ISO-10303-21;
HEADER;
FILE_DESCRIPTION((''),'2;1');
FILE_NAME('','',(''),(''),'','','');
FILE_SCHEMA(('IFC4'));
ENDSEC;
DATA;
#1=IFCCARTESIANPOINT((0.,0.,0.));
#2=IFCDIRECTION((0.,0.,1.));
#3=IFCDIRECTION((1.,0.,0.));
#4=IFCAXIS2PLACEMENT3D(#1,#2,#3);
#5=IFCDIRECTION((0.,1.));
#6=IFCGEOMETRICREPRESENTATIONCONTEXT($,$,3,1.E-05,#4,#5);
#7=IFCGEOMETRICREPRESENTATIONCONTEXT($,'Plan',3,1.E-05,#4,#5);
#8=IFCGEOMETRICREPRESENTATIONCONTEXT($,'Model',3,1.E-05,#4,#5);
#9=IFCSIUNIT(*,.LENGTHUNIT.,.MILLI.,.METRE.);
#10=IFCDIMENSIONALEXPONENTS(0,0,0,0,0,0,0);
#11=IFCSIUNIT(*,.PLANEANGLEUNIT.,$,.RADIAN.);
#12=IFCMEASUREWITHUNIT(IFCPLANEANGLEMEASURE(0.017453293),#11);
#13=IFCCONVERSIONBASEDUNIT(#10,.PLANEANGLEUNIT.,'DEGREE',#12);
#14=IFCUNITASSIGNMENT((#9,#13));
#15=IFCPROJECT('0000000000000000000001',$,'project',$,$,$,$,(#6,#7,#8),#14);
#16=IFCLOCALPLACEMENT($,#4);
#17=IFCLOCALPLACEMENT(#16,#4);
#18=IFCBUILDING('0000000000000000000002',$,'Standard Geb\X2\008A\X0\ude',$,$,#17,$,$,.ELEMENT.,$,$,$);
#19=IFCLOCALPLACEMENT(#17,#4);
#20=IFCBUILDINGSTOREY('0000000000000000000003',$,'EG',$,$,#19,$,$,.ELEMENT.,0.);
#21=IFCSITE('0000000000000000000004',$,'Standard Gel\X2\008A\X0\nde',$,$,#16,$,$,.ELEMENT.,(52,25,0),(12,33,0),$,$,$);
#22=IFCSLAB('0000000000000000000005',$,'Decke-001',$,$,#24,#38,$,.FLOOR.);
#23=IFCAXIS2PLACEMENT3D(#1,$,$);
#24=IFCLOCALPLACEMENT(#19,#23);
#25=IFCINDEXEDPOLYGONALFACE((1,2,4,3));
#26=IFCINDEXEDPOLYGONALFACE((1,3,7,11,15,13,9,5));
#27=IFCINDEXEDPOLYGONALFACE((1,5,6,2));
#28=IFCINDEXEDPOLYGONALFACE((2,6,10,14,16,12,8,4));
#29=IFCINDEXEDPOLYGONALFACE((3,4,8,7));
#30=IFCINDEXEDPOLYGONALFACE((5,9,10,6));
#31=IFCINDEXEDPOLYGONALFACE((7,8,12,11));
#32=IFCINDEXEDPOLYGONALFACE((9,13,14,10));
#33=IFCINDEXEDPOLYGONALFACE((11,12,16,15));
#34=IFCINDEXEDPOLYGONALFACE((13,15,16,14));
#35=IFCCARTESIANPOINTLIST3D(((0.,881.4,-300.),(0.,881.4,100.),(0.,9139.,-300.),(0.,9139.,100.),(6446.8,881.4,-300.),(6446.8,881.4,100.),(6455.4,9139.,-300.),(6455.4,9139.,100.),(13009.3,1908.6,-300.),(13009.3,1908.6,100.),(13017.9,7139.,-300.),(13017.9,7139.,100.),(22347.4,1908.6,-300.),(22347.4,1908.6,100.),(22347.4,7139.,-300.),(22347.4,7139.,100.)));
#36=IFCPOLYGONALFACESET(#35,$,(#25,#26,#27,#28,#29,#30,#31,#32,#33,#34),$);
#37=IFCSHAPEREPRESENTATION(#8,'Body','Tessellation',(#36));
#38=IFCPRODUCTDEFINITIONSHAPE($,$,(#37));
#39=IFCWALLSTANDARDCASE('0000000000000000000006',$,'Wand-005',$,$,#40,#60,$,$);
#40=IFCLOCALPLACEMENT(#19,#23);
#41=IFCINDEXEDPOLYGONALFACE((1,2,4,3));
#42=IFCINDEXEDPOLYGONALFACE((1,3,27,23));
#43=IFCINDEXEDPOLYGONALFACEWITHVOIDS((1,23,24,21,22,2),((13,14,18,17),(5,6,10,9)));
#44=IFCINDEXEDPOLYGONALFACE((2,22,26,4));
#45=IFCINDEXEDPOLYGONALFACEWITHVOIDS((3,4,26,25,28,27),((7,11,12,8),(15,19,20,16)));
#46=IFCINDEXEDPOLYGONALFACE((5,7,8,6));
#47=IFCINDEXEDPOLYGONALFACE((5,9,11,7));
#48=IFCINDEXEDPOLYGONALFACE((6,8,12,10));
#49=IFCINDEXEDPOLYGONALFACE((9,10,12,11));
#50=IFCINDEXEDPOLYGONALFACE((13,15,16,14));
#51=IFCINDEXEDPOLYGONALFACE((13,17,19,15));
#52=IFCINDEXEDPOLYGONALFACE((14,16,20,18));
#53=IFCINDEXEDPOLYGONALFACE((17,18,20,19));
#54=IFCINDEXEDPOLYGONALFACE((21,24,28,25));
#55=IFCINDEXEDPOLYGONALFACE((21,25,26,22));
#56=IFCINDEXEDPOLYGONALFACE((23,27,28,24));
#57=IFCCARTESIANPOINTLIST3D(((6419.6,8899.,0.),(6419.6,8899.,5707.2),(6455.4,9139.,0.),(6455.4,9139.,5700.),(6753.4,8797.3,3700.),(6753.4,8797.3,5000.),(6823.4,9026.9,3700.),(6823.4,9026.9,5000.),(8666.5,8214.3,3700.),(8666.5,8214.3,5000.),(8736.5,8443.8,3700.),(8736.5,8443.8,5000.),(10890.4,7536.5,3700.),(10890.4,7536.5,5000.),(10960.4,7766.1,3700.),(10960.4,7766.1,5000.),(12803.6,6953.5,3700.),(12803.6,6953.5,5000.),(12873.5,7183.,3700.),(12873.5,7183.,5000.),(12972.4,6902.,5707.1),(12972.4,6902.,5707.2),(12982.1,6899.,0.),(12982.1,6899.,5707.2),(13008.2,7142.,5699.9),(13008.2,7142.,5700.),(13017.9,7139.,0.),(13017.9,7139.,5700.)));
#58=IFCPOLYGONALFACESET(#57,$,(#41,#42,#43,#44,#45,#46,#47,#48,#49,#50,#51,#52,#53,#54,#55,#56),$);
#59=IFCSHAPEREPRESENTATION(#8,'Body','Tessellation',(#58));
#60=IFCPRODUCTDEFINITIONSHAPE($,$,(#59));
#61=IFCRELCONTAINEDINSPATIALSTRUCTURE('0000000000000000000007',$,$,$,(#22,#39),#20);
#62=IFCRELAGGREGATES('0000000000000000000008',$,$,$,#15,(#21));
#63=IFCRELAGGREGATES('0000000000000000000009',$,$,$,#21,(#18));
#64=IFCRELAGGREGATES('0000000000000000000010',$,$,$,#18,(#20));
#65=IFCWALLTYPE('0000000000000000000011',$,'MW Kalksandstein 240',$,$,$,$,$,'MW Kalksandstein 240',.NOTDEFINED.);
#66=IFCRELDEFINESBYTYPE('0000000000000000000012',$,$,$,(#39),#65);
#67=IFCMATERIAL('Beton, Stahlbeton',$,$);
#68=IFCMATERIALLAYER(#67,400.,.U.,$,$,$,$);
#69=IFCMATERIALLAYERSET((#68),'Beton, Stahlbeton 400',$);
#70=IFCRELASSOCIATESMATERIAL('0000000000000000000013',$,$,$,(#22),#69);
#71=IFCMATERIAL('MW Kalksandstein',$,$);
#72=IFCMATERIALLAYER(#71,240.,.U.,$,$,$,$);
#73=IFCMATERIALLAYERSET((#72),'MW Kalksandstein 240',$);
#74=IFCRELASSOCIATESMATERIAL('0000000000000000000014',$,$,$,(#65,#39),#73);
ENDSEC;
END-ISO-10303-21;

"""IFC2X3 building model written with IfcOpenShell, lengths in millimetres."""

from ifc_helpers import new_model, entity, si_unit, converted_unit, direction, frame, frame_2d, origin_with_axes, place, context, project, spatial, polyline, rectangle, outline, extrude, clip, bounded_halfspace, material, layer, layer_set, layer_usage, type_object, element, save


model = new_model("IFC2X3")

# Units and contexts
model_context = context("Model", 3, precision=1e-05, world=origin_with_axes(), true_north=direction((0.0, 1.0)))
context_of_model = context(None, 3, precision=1e-05, world=origin_with_axes(), true_north=direction((0.0, 1.0)))
plan_context = context("Plan", 3, precision=1e-05, world=origin_with_axes(), true_north=direction((0.0, 1.0)))
ifc_project = project(units=[si_unit("LENGTHUNIT", "METRE", prefix="MILLI"), converted_unit("PLANEANGLEUNIT", "DEGREE", entity("IfcPlaneAngleMeasure", 0.017453293), si_unit("PLANEANGLEUNIT", "RADIAN"), dimensions=[0, 0, 0, 0, 0, 0, 0])], contexts=[context_of_model, plan_context, model_context])

# Site, building, storey
site_placement = place(None, origin_with_axes())
site = spatial("IfcSite", under=ifc_project, at=site_placement, Name="Standard Gel\u008ande", CompositionType="ELEMENT", RefLatitude=(52, 25, 0), RefLongitude=(12, 33, 0))
building_placement = place(site_placement, origin_with_axes())
building = spatial("IfcBuilding", under=site, at=building_placement, Name="Standard Geb\u008aude", CompositionType="ELEMENT")
storey_placement = place(building_placement, origin_with_axes())
storey = spatial("IfcBuildingStorey", under=building, at=storey_placement, Name="EG", CompositionType="ELEMENT", Elevation=0.0)

# Slab
ifc_material_1 = material(Name="Beton, Stahlbeton")
ifc_layer_1 = layer(ifc_material_1, 400.0, ventilated="UNKNOWN")
ifc_layer_set_1 = layer_set([ifc_layer_1], Name="Beton, Stahlbeton 400")
ifc_layer_usage_1 = layer_usage(ifc_layer_set_1, "AXIS3", "NEGATIVE", 400.0)
slab_placement = place(storey_placement, frame((0.0, 9139.0, -300.0), z_axis=(0.0, 0.0, 1.0), x_axis=(1.0, 0.0, 0.0)))
element("IfcSlab", 1, at=slab_placement, inside=storey, material=ifc_layer_usage_1, Name="Decke-001", PredefinedType="FLOOR", context=model_context, shape_type="SweptSolid", body=[
    extrude(outline(polyline([(0.0, 0.0), (6455.4, 0.0), (13017.9, -2000.0), (22347.4, -2000.0), (22347.4, -7230.5), (13009.3, -7230.5), (6446.8, -8257.7), (0.0, -8257.7), (0.0, 0.0)])), origin_with_axes(), (0.0, 0.0, 1.0), 400.0),
])

# Shared definitions
ifc_material_2 = material(Name="MW Kalksandstein")
ifc_layer_2 = layer(ifc_material_2, 240.0, ventilated="UNKNOWN")
ifc_layer_set_2 = layer_set([ifc_layer_2], Name="MW Kalksandstein 240")
wall_type_1 = type_object("IfcWallType", Name="MW Kalksandstein 240", ElementType="MW Kalksandstein 240", PredefinedType="NOTDEFINED", material=ifc_layer_set_2)

# Wall, openings
ifc_layer_usage_2 = layer_usage(ifc_layer_set_2, "AXIS2", "NEGATIVE", 120.0)
wall_1_placement = place(storey_placement, frame((13000.0, 7019.0, 0.0), z_axis=(0.0, 0.0, 1.0), x_axis=(-0.956563, 0.291524, 0.0)))
wall_1 = element("IfcWallStandardCase", 2, at=wall_1_placement, inside=storey, type_object=wall_type_1, material=ifc_layer_usage_2, Name="Wand-005", context=model_context, shape_type="Clipping", body=[
    clip(clip(clip(extrude(outline(polyline([(17.9, -120.0), (6878.4, -120.0), (6842.6, 120.0), (-17.9, 120.0), (17.9, -120.0)])), origin_with_axes(), (0.0, 0.0, 1.0), 6000.0), bounded_halfspace(frame((49.8, -163.5, 5698.5), z_axis=(0.008742, -0.028684, 0.99955), x_axis=(0.0, 0.999588, 0.028685)), False, origin_with_axes(), polyline([(-7439.4, -240.0), (-7510.9, 240.0), (-25.6, 240.0), (45.9, -240.0), (-7439.4, -240.0)]))), bounded_halfspace(frame((0.0, -171.0, 5698.5), z_axis=(0.0, -0.029987, 0.99955), x_axis=(0.0, 0.99955, 0.029987)), False, origin_with_axes(), polyline([(35.8, -240.0), (-35.8, 240.0), (6824.7, 240.0), (6896.3, -240.0), (35.8, -240.0)]))), bounded_halfspace(frame((50.4, -165.2, 5758.4), z_axis=(0.008742, -0.028684, 0.99955), x_axis=(0.0, 0.999588, 0.028685)), False, origin_with_axes(), polyline([(8748.9, -240.0), (8677.4, 240.0), (6814.6, 240.0), (6886.1, -240.0), (8748.9, -240.0)]))),
])
opening_1_placement = place(wall_1_placement, frame((5493.7, -120.0, 3700.0), z_axis=(0.0, 0.0, 1.0), x_axis=(1.0, 0.0, 0.0)))
element("IfcOpeningElement", 3, at=opening_1_placement, cuts=wall_1, ObjectType="Opening", context=model_context, shape_type="SweptSolid", body=[
    extrude(rectangle(XDim=2000.0, YDim=1300.0, at=frame_2d((0.0, 650.0), x_axis=(-1.0, 0.0))), frame((0.0, 0.0, 0.0), z_axis=(0.0, 1.0, 0.0), x_axis=(-1.0, 0.0, 0.0)), (0.0, 0.0, 1.0), 240.0),
])
opening_2_placement = place(wall_1_placement, frame((1168.8, -120.0, 3700.0), z_axis=(0.0, 0.0, 1.0), x_axis=(1.0, 0.0, 0.0)))
element("IfcOpeningElement", 4, at=opening_2_placement, cuts=wall_1, ObjectType="Opening", context=model_context, shape_type="SweptSolid", body=[
    extrude(rectangle(XDim=2000.0, YDim=1300.0, at=frame_2d((0.0, 650.0), x_axis=(1.0, 0.0))), frame((0.0, 0.0, 0.0), z_axis=(0.0, 1.0, 0.0), x_axis=(-1.0, 0.0, 0.0)), (0.0, 0.0, 1.0), 240.0),
])

save(model, "model.ifc")
